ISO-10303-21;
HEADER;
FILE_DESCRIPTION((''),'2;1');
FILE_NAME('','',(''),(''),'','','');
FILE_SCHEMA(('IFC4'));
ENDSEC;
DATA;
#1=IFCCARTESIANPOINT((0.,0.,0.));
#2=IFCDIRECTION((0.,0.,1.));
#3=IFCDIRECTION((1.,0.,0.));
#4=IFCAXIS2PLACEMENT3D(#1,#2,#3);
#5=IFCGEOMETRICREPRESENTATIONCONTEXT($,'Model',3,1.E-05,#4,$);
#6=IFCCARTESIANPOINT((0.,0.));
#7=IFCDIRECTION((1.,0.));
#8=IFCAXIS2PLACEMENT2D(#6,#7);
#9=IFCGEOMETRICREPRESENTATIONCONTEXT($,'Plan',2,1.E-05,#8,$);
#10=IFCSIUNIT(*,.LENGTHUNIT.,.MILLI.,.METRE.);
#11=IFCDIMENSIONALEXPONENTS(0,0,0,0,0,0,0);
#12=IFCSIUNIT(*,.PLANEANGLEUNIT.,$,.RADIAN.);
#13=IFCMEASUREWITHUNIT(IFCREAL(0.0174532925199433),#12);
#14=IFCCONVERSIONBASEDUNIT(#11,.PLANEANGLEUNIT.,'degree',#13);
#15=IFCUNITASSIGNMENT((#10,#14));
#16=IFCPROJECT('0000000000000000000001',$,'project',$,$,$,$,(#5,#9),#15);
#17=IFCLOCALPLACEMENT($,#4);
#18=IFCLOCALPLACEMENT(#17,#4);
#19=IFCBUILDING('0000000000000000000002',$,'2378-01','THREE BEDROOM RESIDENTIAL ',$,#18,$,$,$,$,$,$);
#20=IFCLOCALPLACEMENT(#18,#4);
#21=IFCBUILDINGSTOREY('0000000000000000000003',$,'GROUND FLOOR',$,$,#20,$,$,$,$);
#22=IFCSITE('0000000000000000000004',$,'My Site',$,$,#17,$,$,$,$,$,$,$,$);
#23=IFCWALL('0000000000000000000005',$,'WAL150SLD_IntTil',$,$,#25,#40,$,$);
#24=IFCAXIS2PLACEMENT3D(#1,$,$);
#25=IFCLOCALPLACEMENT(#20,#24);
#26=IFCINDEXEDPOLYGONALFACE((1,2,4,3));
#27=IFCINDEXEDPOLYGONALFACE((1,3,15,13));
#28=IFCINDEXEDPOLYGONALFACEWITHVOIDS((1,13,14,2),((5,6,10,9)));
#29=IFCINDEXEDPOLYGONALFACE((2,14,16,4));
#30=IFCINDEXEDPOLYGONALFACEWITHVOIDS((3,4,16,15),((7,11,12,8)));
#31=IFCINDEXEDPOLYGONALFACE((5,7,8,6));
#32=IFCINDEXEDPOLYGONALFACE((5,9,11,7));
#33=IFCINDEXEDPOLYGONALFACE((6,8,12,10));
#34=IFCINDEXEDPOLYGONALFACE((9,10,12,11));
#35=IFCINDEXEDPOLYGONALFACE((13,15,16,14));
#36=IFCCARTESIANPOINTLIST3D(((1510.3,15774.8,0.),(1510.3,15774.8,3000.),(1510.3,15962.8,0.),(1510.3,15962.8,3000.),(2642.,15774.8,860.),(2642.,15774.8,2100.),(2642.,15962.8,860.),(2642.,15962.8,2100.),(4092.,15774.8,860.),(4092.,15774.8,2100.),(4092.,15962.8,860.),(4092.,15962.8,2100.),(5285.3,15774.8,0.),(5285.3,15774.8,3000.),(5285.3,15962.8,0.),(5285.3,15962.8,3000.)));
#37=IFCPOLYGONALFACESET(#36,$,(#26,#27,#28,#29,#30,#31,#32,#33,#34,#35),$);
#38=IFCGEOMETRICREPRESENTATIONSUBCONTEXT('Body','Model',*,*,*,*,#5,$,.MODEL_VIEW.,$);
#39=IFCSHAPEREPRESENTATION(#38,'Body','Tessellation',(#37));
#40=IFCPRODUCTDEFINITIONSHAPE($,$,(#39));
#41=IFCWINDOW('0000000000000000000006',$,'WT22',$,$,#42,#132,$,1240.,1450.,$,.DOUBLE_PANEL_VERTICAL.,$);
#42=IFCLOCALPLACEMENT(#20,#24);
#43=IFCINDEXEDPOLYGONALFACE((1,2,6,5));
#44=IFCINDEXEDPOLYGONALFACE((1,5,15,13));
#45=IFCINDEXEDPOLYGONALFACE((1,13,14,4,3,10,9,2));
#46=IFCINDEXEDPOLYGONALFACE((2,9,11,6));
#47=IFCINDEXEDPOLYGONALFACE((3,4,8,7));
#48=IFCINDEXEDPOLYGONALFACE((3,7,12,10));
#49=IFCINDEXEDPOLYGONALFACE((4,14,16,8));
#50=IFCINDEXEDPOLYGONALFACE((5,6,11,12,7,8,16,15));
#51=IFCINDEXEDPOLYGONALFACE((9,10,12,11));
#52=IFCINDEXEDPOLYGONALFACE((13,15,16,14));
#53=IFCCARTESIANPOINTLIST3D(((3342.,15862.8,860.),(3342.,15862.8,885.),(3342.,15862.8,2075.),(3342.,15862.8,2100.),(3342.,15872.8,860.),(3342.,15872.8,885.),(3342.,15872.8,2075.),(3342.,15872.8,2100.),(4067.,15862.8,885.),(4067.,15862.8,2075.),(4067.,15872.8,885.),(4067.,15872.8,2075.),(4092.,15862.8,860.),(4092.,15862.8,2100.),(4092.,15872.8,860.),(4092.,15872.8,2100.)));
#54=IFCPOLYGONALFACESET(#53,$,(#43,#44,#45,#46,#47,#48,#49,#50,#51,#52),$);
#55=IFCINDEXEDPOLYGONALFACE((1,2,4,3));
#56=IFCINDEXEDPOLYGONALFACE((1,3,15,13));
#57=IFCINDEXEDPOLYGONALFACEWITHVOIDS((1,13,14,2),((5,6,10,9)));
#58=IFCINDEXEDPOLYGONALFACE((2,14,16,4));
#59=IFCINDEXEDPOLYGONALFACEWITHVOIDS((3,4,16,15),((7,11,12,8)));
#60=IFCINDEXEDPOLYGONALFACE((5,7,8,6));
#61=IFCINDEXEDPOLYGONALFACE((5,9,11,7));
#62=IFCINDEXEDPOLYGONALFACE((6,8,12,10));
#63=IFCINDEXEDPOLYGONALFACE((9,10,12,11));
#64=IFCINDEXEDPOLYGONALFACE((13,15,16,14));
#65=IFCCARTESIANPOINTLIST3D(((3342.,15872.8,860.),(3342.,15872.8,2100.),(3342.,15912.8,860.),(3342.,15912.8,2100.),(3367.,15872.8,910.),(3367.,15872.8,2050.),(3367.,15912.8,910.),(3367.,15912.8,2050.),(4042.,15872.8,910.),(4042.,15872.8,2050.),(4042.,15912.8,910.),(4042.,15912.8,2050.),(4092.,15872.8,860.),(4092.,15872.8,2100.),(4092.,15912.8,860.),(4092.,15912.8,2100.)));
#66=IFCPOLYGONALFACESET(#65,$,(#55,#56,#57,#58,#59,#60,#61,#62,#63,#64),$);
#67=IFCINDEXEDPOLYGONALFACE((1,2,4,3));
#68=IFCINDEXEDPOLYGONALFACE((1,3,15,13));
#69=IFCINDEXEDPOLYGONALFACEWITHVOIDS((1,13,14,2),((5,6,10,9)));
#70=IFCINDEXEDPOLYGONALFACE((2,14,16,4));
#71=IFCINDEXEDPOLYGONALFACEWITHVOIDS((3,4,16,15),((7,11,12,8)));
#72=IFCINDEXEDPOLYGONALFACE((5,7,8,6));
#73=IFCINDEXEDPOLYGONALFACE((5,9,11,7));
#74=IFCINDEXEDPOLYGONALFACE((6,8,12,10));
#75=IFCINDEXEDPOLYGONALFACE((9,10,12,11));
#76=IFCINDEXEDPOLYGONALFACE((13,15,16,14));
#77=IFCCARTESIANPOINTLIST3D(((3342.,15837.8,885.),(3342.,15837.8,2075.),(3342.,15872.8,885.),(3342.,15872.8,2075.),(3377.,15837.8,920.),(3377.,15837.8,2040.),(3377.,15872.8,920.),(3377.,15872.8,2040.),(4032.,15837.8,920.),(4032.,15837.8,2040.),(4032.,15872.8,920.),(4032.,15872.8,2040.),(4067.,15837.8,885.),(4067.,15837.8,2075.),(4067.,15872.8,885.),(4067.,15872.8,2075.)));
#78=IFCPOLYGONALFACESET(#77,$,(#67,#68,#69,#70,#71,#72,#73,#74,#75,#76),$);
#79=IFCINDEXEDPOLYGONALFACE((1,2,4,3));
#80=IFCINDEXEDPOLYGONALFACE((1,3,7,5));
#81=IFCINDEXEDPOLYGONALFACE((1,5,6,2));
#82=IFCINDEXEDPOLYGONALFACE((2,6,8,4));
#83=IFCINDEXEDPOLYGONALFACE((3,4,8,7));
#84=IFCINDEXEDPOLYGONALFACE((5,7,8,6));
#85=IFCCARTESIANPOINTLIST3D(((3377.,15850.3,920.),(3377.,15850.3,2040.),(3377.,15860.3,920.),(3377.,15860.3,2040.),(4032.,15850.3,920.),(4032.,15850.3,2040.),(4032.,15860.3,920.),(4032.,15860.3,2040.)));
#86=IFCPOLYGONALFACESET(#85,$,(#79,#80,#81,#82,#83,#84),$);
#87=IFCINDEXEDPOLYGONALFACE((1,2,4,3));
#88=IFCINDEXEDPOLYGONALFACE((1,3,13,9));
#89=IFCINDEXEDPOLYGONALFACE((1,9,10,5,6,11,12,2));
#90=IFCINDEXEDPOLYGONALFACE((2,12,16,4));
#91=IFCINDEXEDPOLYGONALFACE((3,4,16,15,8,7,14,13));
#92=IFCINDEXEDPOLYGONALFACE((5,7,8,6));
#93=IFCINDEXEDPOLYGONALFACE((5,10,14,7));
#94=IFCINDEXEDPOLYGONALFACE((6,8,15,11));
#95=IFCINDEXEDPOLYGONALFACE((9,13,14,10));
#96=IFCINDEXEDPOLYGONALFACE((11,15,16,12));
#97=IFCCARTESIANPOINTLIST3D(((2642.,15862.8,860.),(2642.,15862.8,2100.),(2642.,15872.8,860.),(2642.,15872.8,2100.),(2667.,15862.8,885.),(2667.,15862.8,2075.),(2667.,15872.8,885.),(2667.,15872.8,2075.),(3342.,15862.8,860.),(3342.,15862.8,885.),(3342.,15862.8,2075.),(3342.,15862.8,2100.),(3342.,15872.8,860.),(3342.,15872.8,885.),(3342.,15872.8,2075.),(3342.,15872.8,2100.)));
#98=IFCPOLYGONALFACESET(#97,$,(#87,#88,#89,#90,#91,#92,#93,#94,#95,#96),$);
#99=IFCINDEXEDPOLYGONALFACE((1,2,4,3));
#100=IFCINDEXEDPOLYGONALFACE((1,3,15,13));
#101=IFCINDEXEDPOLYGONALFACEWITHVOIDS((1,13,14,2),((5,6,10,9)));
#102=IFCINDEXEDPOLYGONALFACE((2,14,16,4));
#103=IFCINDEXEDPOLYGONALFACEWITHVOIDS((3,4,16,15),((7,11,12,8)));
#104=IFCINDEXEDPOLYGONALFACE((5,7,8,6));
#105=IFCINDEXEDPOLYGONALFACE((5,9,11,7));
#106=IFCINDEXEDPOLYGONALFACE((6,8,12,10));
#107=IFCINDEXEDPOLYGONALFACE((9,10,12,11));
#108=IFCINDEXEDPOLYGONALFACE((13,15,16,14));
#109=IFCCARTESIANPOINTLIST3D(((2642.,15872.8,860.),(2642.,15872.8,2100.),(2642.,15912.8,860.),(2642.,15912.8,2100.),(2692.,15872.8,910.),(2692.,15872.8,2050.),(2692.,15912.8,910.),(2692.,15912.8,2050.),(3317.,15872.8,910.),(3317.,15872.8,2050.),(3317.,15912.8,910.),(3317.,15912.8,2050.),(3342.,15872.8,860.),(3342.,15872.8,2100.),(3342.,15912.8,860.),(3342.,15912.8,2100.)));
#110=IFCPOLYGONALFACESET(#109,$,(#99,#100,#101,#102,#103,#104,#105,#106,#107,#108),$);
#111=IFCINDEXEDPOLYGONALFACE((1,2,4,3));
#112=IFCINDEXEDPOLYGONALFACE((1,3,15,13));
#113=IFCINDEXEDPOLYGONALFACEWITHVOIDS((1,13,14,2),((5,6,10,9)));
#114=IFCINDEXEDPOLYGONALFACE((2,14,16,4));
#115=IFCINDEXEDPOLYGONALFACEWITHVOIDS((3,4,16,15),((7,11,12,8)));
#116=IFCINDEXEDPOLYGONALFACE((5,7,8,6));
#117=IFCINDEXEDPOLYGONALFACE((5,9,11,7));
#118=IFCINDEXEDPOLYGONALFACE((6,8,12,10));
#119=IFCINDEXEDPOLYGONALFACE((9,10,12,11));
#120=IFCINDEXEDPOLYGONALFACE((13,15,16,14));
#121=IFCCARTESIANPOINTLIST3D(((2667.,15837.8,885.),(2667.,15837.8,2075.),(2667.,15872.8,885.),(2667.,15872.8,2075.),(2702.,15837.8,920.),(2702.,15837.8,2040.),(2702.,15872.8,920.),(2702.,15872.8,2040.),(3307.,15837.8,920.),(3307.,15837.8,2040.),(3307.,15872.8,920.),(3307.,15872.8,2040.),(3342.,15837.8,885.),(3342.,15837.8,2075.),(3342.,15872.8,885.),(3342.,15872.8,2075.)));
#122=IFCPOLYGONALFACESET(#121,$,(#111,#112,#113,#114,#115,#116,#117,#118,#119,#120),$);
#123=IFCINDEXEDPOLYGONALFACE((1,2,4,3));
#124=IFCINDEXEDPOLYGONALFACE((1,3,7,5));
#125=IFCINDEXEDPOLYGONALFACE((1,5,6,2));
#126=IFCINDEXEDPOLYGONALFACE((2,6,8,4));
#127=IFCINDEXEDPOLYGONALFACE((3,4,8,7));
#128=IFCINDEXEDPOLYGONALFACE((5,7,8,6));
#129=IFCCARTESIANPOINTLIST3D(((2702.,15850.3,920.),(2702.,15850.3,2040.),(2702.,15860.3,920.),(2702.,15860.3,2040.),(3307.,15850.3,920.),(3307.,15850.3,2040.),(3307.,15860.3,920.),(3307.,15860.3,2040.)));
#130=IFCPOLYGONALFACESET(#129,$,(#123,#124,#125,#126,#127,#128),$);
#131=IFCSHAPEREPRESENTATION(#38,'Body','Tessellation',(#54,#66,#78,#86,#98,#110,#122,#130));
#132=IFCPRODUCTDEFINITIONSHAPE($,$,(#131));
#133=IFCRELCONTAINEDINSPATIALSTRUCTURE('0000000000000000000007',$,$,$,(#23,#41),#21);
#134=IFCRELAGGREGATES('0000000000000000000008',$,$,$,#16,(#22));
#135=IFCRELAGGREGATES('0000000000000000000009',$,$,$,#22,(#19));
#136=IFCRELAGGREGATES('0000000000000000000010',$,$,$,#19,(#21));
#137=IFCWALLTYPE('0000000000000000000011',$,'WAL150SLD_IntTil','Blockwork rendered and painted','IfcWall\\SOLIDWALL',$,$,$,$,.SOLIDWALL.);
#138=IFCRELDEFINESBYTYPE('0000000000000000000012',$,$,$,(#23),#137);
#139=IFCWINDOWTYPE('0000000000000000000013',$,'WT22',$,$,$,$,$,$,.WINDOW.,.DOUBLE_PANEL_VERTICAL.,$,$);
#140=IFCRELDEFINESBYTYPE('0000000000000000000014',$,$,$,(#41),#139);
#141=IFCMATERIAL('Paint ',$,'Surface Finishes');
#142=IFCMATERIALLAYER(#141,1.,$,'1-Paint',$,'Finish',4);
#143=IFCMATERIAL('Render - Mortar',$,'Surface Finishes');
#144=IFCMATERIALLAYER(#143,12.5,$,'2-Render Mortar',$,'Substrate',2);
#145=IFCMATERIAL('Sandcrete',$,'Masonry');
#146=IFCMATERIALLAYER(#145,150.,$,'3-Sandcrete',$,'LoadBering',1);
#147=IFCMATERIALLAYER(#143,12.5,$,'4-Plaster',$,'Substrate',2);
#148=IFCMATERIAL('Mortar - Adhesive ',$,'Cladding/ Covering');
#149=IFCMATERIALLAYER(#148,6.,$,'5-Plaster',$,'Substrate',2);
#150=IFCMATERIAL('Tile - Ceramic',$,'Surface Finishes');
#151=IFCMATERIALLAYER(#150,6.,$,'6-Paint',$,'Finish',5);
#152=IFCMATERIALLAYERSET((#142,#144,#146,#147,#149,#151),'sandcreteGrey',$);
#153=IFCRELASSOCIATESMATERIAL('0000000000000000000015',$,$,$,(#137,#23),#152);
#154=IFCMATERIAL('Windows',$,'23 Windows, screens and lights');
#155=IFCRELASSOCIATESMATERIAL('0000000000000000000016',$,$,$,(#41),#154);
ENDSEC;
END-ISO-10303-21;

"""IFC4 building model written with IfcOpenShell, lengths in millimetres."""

from ifc_helpers import new_model, entity, si_unit, converted_unit, frame, origin_with_axes, origin_2d_with_axis, place, context, subcontext, project, spatial, line, indexed_curve, outline, extrude, shape, source, transform, mapped, material, layer, layer_set, layer_usage, type_object, type_shapes, element, fill, save


model = new_model("IFC4")

# Units and contexts
model_context = context("Model", 3, precision=1e-05, world=origin_with_axes())
plan_context = context("Plan", 2, precision=1e-05, world=origin_2d_with_axis())
body_context_1 = subcontext(model_context, "Body", "Model", "MODEL_VIEW")
body_context_2 = subcontext(plan_context, "Body", "Plan", "PLAN_VIEW")
ifc_project = project(units=[si_unit("LENGTHUNIT", "METRE", prefix="MILLI"), converted_unit("PLANEANGLEUNIT", "degree", entity("IfcReal", 0.0174532925199433), si_unit("PLANEANGLEUNIT", "RADIAN"), dimensions=[0, 0, 0, 0, 0, 0, 0])], contexts=[model_context, plan_context])

# Site, building, storey
site_placement = place(None, origin_with_axes())
site = spatial("IfcSite", under=ifc_project, at=site_placement, Name="My Site")
building_placement = place(site_placement, origin_with_axes())
building = spatial("IfcBuilding", under=site, at=building_placement, Name="2378-01", Description="THREE BEDROOM RESIDENTIAL ")
storey_placement = place(building_placement, origin_with_axes())
storey = spatial("IfcBuildingStorey", under=building, at=storey_placement, Name="GROUND FLOOR")

# Shared definitions
ifc_material_1 = material(Name="Windows", Category="23 Windows, screens and lights")

# Shared definitions
ifc_material_2 = material(Name="Paint ", Category="Surface Finishes")
ifc_material_3 = material(Name="Render - Mortar", Category="Surface Finishes")
ifc_material_4 = material(Name="Sandcrete", Category="Masonry")

# Shared definitions
ifc_material_5 = material(Name="Mortar - Adhesive ", Category="Cladding/ Covering")
ifc_material_6 = material(Name="Tile - Ceramic", Category="Surface Finishes")

# Wall, opening, window
ifc_layer_1 = layer(ifc_material_2, 1.0, Name="1-Paint", Category="Finish", Priority=4)
ifc_layer_2 = layer(ifc_material_3, 12.5, Name="2-Render Mortar", Category="Substrate", Priority=2)
ifc_layer_3 = layer(ifc_material_4, 150.0, Name="3-Sandcrete", Category="LoadBering", Priority=1)
ifc_layer_4 = layer(ifc_material_3, 12.5, Name="4-Plaster", Category="Substrate", Priority=2)
ifc_layer_5 = layer(ifc_material_5, 6.0, Name="5-Plaster", Category="Substrate", Priority=2)
ifc_layer_6 = layer(ifc_material_6, 6.0, Name="6-Paint", Category="Finish", Priority=5)
ifc_layer_set_1 = layer_set([ifc_layer_1, ifc_layer_2, ifc_layer_3, ifc_layer_4, ifc_layer_5, ifc_layer_6], Name="sandcreteGrey")
ifc_layer_usage_1 = layer_usage(ifc_layer_set_1, "AXIS2", "POSITIVE", 0.0)
wall_type_1 = type_object("IfcWallType", Name="WAL150SLD_IntTil", Description="Blockwork rendered and painted", ApplicableOccurrence="IfcWall\\SOLIDWALL", PredefinedType="SOLIDWALL", material=ifc_layer_set_1)
wall_1_placement = place(storey_placement, frame((5285.3, 15962.8, 0.0), z_axis=(0.0, 0.0, 1.0), x_axis=(-1.0, 0.000001, 0.0)))
wall_1 = element("IfcWall", 1, at=wall_1_placement, inside=storey, type_object=wall_type_1, material=ifc_layer_usage_1, Name="WAL150SLD_IntTil", context=body_context_1, shape_type="SweptSolid", body=[
    extrude(outline(indexed_curve([(0.0, 0.0), (0.0, 188.0), (3775.0, 188.0), (3775.0, 0.0), (0.0, 0.0)], self_intersect=False)), origin_with_axes(), (0.0, 0.0, 1.0), 3000.0),
])
shared_shape_1 = source(origin_with_axes(), body_context_1, "Body", "SweptSolid", [
    extrude(outline(indexed_curve([(0.0, 0.0), (1450.0, 0.0), (1450.0, 1240.0), (0.0, 1240.0)], segments=[line(1, 2, 3, 4, 1)])), frame((0.0, -100.0, 0.0), z_axis=(0.0, -1.0, 0.0), x_axis=(1.0, 0.0, 0.0)), (0.0, 0.0, -1.0), 388.0),
])
opening_1_placement = place(wall_1_placement, frame((1193.3, 0.0, 860.0), z_axis=(0.0, 0.0, 1.0), x_axis=(1.0, 0.0, 0.0)))
opening_1 = element("IfcOpeningElement", 2, at=opening_1_placement, cuts=wall_1, PredefinedType="OPENING", context=body_context_1, shape_type="MappedRepresentation", body=[
    mapped(shared_shape_1, transform((0.0, 0.0, 0.0), x_axis=(1.0, 0.0, 0.0), y_axis=(0.0, 1.0, 0.0), z_axis=(0.0, 0.0, 1.0), scale=1.0)),
])
window_type_1 = type_object("IfcWindowType", Name="WT22", PartitioningType="DOUBLE_PANEL_VERTICAL", PredefinedType="WINDOW")
shared_shape_2 = source(origin_with_axes(), body_context_1, "Body", "SweptSolid", [
    extrude(outline(indexed_curve([(750.0, 0.0), (0.0, 0.0), (0.0, 1240.0), (750.0, 1240.0), (750.0, 1215.0), (25.0, 1215.0), (25.0, 25.0), (750.0, 25.0)], segments=[line(1, 2, 3, 4, 5, 6, 7, 8, 1)])), frame((0.0, 90.0, 0.0), z_axis=(0.0, -1.0, 0.0), x_axis=(1.0, 0.0, 0.0)), (0.0, 0.0, -1.0), 10.0),
    extrude(outline(indexed_curve([(0.0, 0.0), (750.0, 0.0), (750.0, 1240.0), (0.0, 1240.0)], segments=[line(1, 2, 3, 4, 1)]), holes=[indexed_curve([(50.0, 50.0), (725.0, 50.0), (725.0, 1190.0), (50.0, 1190.0)], segments=[line(1, 2, 3, 4, 1)])]), frame((0.0, 50.0, 0.0), z_axis=(0.0, -1.0, 0.0), x_axis=(1.0, 0.0, 0.0)), (0.0, 0.0, -1.0), 40.0),
    extrude(outline(indexed_curve([(0.0, 0.0), (725.0, 0.0), (725.0, 1190.0), (0.0, 1190.0)], segments=[line(1, 2, 3, 4, 1)]), holes=[indexed_curve([(35.0, 35.0), (690.0, 35.0), (690.0, 1155.0), (35.0, 1155.0)], segments=[line(1, 2, 3, 4, 1)])]), frame((25.0, 90.0, 25.0), z_axis=(0.0, -1.0, 0.0), x_axis=(1.0, 0.0, 0.0)), (0.0, 0.0, -1.0), 35.0),
    extrude(outline(indexed_curve([(35.0, 35.0), (690.0, 35.0), (690.0, 1155.0), (35.0, 1155.0)], segments=[line(1, 2, 3, 4, 1)])), frame((25.0, 102.5, 25.0), z_axis=(0.0, -1.0, 0.0), x_axis=(1.0, 0.0, 0.0)), (0.0, 0.0, -1.0), 10.0),
    extrude(outline(indexed_curve([(0.0, 1240.0), (700.0, 1240.0), (700.0, 0.0), (0.0, 0.0), (0.0, 25.0), (675.0, 25.0), (675.0, 1215.0), (0.0, 1215.0)], segments=[line(1, 2, 3, 4, 5, 6, 7, 8, 1)])), frame((750.0, 90.0, 0.0), z_axis=(0.0, -1.0, 0.0), x_axis=(1.0, 0.0, 0.0)), (0.0, 0.0, -1.0), 10.0),
    extrude(outline(indexed_curve([(0.0, 0.0), (700.0, 0.0), (700.0, 1240.0), (0.0, 1240.0)], segments=[line(1, 2, 3, 4, 1)]), holes=[indexed_curve([(25.0, 50.0), (650.0, 50.0), (650.0, 1190.0), (25.0, 1190.0)], segments=[line(1, 2, 3, 4, 1)])]), frame((750.0, 50.0, 0.0), z_axis=(0.0, -1.0, 0.0), x_axis=(1.0, 0.0, 0.0)), (0.0, 0.0, -1.0), 40.0),
    extrude(outline(indexed_curve([(0.0, 0.0), (675.0, 0.0), (675.0, 1190.0), (0.0, 1190.0)], segments=[line(1, 2, 3, 4, 1)]), holes=[indexed_curve([(35.0, 35.0), (640.0, 35.0), (640.0, 1155.0), (35.0, 1155.0)], segments=[line(1, 2, 3, 4, 1)])]), frame((750.0, 90.0, 25.0), z_axis=(0.0, -1.0, 0.0), x_axis=(1.0, 0.0, 0.0)), (0.0, 0.0, -1.0), 35.0),
    extrude(outline(indexed_curve([(35.0, 35.0), (640.0, 35.0), (640.0, 1155.0), (35.0, 1155.0)], segments=[line(1, 2, 3, 4, 1)])), frame((750.0, 102.5, 25.0), z_axis=(0.0, -1.0, 0.0), x_axis=(1.0, 0.0, 0.0)), (0.0, 0.0, -1.0), 10.0),
])
shared_shape_3 = source(origin_with_axes(), body_context_2, "Body", "Curve2D", [
    entity("IfcIndexedPolyCurve", entity("IfcCartesianPointList2D", [[50.0, 50.0], [725.0, 50.0]])),
    entity("IfcIndexedPolyCurve", entity("IfcCartesianPointList2D", [[0.0, 100.0], [25.0, 100.0], [25.0, 90.0], [50.0, 90.0], [50.0, 50.0], [0.0, 50.0]]), [entity("IfcLineIndex", [1, 2, 3, 4, 5, 6, 1])]),
    entity("IfcIndexedPolyCurve", entity("IfcCartesianPointList2D", [[750.0, 100.0], [750.0, 100.0], [750.0, 90.0], [725.0, 90.0], [725.0, 50.0], [750.0, 50.0]])),
    entity("IfcIndexedPolyCurve", entity("IfcCartesianPointList2D", [[25.0, 90.0], [60.0, 90.0], [60.0, 125.0], [25.0, 125.0]]), [entity("IfcLineIndex", [1, 2, 3, 4, 1])]),
    entity("IfcIndexedPolyCurve", entity("IfcCartesianPointList2D", [[750.0, 90.0], [715.0, 90.0], [715.0, 125.0], [750.0, 125.0]]), [entity("IfcLineIndex", [1, 2, 3, 4, 1])]),
    entity("IfcIndexedPolyCurve", entity("IfcCartesianPointList2D", [[60.0, 90.0], [715.0, 90.0]])),
    entity("IfcIndexedPolyCurve", entity("IfcCartesianPointList2D", [[60.0, 125.0], [715.0, 125.0]])),
    entity("IfcIndexedPolyCurve", entity("IfcCartesianPointList2D", [[60.0, 107.5], [715.0, 107.5]])),
    entity("IfcIndexedPolyCurve", entity("IfcCartesianPointList2D", [[775.0, 50.0], [1400.0, 50.0]])),
    entity("IfcIndexedPolyCurve", entity("IfcCartesianPointList2D", [[750.0, 100.0], [750.0, 100.0], [750.0, 90.0], [775.0, 90.0], [775.0, 50.0], [750.0, 50.0]])),
    entity("IfcIndexedPolyCurve", entity("IfcCartesianPointList2D", [[1450.0, 100.0], [1425.0, 100.0], [1425.0, 90.0], [1400.0, 90.0], [1400.0, 50.0], [1450.0, 50.0]]), [entity("IfcLineIndex", [1, 2, 3, 4, 5, 6, 1])]),
    entity("IfcIndexedPolyCurve", entity("IfcCartesianPointList2D", [[750.0, 90.0], [785.0, 90.0], [785.0, 125.0], [750.0, 125.0]]), [entity("IfcLineIndex", [1, 2, 3, 4, 1])]),
    entity("IfcIndexedPolyCurve", entity("IfcCartesianPointList2D", [[1425.0, 90.0], [1390.0, 90.0], [1390.0, 125.0], [1425.0, 125.0]]), [entity("IfcLineIndex", [1, 2, 3, 4, 1])]),
    entity("IfcIndexedPolyCurve", entity("IfcCartesianPointList2D", [[785.0, 90.0], [1390.0, 90.0]])),
    entity("IfcIndexedPolyCurve", entity("IfcCartesianPointList2D", [[785.0, 125.0], [1390.0, 125.0]])),
    entity("IfcIndexedPolyCurve", entity("IfcCartesianPointList2D", [[785.0, 107.5], [1390.0, 107.5]])),
])
type_shapes(window_type_1, [shared_shape_2, shared_shape_3])
window_1_placement = place(opening_1_placement, frame((0.0, 0.0, 0.0), z_axis=(0.0, 0.0, 1.0), x_axis=(1.0, 0.0, 0.0)))
window_1 = element("IfcWindow", 3, at=window_1_placement, inside=storey, type_object=window_type_1, material=ifc_material_1, Name="WT22", OverallHeight=1240.0, OverallWidth=1450.0, PartitioningType="DOUBLE_PANEL_VERTICAL", shapes=[
    shape(body_context_1, "Body", "MappedRepresentation", [mapped(shared_shape_2, transform((0.0, 0.0, 0.0), x_axis=(1.0, 0.0, 0.0), y_axis=(0.0, 1.0, 0.0), z_axis=(0.0, 0.0, 1.0), scale=1.0))]),
    shape(body_context_2, "Body", "MappedRepresentation", [mapped(shared_shape_3, transform((0.0, 0.0, 0.0), x_axis=(1.0, 0.0, 0.0), y_axis=(0.0, 1.0, 0.0), z_axis=(0.0, 0.0, 1.0), scale=1.0))]),
])
fill(opening_1, window_1)

save(model, "model.ifc")
